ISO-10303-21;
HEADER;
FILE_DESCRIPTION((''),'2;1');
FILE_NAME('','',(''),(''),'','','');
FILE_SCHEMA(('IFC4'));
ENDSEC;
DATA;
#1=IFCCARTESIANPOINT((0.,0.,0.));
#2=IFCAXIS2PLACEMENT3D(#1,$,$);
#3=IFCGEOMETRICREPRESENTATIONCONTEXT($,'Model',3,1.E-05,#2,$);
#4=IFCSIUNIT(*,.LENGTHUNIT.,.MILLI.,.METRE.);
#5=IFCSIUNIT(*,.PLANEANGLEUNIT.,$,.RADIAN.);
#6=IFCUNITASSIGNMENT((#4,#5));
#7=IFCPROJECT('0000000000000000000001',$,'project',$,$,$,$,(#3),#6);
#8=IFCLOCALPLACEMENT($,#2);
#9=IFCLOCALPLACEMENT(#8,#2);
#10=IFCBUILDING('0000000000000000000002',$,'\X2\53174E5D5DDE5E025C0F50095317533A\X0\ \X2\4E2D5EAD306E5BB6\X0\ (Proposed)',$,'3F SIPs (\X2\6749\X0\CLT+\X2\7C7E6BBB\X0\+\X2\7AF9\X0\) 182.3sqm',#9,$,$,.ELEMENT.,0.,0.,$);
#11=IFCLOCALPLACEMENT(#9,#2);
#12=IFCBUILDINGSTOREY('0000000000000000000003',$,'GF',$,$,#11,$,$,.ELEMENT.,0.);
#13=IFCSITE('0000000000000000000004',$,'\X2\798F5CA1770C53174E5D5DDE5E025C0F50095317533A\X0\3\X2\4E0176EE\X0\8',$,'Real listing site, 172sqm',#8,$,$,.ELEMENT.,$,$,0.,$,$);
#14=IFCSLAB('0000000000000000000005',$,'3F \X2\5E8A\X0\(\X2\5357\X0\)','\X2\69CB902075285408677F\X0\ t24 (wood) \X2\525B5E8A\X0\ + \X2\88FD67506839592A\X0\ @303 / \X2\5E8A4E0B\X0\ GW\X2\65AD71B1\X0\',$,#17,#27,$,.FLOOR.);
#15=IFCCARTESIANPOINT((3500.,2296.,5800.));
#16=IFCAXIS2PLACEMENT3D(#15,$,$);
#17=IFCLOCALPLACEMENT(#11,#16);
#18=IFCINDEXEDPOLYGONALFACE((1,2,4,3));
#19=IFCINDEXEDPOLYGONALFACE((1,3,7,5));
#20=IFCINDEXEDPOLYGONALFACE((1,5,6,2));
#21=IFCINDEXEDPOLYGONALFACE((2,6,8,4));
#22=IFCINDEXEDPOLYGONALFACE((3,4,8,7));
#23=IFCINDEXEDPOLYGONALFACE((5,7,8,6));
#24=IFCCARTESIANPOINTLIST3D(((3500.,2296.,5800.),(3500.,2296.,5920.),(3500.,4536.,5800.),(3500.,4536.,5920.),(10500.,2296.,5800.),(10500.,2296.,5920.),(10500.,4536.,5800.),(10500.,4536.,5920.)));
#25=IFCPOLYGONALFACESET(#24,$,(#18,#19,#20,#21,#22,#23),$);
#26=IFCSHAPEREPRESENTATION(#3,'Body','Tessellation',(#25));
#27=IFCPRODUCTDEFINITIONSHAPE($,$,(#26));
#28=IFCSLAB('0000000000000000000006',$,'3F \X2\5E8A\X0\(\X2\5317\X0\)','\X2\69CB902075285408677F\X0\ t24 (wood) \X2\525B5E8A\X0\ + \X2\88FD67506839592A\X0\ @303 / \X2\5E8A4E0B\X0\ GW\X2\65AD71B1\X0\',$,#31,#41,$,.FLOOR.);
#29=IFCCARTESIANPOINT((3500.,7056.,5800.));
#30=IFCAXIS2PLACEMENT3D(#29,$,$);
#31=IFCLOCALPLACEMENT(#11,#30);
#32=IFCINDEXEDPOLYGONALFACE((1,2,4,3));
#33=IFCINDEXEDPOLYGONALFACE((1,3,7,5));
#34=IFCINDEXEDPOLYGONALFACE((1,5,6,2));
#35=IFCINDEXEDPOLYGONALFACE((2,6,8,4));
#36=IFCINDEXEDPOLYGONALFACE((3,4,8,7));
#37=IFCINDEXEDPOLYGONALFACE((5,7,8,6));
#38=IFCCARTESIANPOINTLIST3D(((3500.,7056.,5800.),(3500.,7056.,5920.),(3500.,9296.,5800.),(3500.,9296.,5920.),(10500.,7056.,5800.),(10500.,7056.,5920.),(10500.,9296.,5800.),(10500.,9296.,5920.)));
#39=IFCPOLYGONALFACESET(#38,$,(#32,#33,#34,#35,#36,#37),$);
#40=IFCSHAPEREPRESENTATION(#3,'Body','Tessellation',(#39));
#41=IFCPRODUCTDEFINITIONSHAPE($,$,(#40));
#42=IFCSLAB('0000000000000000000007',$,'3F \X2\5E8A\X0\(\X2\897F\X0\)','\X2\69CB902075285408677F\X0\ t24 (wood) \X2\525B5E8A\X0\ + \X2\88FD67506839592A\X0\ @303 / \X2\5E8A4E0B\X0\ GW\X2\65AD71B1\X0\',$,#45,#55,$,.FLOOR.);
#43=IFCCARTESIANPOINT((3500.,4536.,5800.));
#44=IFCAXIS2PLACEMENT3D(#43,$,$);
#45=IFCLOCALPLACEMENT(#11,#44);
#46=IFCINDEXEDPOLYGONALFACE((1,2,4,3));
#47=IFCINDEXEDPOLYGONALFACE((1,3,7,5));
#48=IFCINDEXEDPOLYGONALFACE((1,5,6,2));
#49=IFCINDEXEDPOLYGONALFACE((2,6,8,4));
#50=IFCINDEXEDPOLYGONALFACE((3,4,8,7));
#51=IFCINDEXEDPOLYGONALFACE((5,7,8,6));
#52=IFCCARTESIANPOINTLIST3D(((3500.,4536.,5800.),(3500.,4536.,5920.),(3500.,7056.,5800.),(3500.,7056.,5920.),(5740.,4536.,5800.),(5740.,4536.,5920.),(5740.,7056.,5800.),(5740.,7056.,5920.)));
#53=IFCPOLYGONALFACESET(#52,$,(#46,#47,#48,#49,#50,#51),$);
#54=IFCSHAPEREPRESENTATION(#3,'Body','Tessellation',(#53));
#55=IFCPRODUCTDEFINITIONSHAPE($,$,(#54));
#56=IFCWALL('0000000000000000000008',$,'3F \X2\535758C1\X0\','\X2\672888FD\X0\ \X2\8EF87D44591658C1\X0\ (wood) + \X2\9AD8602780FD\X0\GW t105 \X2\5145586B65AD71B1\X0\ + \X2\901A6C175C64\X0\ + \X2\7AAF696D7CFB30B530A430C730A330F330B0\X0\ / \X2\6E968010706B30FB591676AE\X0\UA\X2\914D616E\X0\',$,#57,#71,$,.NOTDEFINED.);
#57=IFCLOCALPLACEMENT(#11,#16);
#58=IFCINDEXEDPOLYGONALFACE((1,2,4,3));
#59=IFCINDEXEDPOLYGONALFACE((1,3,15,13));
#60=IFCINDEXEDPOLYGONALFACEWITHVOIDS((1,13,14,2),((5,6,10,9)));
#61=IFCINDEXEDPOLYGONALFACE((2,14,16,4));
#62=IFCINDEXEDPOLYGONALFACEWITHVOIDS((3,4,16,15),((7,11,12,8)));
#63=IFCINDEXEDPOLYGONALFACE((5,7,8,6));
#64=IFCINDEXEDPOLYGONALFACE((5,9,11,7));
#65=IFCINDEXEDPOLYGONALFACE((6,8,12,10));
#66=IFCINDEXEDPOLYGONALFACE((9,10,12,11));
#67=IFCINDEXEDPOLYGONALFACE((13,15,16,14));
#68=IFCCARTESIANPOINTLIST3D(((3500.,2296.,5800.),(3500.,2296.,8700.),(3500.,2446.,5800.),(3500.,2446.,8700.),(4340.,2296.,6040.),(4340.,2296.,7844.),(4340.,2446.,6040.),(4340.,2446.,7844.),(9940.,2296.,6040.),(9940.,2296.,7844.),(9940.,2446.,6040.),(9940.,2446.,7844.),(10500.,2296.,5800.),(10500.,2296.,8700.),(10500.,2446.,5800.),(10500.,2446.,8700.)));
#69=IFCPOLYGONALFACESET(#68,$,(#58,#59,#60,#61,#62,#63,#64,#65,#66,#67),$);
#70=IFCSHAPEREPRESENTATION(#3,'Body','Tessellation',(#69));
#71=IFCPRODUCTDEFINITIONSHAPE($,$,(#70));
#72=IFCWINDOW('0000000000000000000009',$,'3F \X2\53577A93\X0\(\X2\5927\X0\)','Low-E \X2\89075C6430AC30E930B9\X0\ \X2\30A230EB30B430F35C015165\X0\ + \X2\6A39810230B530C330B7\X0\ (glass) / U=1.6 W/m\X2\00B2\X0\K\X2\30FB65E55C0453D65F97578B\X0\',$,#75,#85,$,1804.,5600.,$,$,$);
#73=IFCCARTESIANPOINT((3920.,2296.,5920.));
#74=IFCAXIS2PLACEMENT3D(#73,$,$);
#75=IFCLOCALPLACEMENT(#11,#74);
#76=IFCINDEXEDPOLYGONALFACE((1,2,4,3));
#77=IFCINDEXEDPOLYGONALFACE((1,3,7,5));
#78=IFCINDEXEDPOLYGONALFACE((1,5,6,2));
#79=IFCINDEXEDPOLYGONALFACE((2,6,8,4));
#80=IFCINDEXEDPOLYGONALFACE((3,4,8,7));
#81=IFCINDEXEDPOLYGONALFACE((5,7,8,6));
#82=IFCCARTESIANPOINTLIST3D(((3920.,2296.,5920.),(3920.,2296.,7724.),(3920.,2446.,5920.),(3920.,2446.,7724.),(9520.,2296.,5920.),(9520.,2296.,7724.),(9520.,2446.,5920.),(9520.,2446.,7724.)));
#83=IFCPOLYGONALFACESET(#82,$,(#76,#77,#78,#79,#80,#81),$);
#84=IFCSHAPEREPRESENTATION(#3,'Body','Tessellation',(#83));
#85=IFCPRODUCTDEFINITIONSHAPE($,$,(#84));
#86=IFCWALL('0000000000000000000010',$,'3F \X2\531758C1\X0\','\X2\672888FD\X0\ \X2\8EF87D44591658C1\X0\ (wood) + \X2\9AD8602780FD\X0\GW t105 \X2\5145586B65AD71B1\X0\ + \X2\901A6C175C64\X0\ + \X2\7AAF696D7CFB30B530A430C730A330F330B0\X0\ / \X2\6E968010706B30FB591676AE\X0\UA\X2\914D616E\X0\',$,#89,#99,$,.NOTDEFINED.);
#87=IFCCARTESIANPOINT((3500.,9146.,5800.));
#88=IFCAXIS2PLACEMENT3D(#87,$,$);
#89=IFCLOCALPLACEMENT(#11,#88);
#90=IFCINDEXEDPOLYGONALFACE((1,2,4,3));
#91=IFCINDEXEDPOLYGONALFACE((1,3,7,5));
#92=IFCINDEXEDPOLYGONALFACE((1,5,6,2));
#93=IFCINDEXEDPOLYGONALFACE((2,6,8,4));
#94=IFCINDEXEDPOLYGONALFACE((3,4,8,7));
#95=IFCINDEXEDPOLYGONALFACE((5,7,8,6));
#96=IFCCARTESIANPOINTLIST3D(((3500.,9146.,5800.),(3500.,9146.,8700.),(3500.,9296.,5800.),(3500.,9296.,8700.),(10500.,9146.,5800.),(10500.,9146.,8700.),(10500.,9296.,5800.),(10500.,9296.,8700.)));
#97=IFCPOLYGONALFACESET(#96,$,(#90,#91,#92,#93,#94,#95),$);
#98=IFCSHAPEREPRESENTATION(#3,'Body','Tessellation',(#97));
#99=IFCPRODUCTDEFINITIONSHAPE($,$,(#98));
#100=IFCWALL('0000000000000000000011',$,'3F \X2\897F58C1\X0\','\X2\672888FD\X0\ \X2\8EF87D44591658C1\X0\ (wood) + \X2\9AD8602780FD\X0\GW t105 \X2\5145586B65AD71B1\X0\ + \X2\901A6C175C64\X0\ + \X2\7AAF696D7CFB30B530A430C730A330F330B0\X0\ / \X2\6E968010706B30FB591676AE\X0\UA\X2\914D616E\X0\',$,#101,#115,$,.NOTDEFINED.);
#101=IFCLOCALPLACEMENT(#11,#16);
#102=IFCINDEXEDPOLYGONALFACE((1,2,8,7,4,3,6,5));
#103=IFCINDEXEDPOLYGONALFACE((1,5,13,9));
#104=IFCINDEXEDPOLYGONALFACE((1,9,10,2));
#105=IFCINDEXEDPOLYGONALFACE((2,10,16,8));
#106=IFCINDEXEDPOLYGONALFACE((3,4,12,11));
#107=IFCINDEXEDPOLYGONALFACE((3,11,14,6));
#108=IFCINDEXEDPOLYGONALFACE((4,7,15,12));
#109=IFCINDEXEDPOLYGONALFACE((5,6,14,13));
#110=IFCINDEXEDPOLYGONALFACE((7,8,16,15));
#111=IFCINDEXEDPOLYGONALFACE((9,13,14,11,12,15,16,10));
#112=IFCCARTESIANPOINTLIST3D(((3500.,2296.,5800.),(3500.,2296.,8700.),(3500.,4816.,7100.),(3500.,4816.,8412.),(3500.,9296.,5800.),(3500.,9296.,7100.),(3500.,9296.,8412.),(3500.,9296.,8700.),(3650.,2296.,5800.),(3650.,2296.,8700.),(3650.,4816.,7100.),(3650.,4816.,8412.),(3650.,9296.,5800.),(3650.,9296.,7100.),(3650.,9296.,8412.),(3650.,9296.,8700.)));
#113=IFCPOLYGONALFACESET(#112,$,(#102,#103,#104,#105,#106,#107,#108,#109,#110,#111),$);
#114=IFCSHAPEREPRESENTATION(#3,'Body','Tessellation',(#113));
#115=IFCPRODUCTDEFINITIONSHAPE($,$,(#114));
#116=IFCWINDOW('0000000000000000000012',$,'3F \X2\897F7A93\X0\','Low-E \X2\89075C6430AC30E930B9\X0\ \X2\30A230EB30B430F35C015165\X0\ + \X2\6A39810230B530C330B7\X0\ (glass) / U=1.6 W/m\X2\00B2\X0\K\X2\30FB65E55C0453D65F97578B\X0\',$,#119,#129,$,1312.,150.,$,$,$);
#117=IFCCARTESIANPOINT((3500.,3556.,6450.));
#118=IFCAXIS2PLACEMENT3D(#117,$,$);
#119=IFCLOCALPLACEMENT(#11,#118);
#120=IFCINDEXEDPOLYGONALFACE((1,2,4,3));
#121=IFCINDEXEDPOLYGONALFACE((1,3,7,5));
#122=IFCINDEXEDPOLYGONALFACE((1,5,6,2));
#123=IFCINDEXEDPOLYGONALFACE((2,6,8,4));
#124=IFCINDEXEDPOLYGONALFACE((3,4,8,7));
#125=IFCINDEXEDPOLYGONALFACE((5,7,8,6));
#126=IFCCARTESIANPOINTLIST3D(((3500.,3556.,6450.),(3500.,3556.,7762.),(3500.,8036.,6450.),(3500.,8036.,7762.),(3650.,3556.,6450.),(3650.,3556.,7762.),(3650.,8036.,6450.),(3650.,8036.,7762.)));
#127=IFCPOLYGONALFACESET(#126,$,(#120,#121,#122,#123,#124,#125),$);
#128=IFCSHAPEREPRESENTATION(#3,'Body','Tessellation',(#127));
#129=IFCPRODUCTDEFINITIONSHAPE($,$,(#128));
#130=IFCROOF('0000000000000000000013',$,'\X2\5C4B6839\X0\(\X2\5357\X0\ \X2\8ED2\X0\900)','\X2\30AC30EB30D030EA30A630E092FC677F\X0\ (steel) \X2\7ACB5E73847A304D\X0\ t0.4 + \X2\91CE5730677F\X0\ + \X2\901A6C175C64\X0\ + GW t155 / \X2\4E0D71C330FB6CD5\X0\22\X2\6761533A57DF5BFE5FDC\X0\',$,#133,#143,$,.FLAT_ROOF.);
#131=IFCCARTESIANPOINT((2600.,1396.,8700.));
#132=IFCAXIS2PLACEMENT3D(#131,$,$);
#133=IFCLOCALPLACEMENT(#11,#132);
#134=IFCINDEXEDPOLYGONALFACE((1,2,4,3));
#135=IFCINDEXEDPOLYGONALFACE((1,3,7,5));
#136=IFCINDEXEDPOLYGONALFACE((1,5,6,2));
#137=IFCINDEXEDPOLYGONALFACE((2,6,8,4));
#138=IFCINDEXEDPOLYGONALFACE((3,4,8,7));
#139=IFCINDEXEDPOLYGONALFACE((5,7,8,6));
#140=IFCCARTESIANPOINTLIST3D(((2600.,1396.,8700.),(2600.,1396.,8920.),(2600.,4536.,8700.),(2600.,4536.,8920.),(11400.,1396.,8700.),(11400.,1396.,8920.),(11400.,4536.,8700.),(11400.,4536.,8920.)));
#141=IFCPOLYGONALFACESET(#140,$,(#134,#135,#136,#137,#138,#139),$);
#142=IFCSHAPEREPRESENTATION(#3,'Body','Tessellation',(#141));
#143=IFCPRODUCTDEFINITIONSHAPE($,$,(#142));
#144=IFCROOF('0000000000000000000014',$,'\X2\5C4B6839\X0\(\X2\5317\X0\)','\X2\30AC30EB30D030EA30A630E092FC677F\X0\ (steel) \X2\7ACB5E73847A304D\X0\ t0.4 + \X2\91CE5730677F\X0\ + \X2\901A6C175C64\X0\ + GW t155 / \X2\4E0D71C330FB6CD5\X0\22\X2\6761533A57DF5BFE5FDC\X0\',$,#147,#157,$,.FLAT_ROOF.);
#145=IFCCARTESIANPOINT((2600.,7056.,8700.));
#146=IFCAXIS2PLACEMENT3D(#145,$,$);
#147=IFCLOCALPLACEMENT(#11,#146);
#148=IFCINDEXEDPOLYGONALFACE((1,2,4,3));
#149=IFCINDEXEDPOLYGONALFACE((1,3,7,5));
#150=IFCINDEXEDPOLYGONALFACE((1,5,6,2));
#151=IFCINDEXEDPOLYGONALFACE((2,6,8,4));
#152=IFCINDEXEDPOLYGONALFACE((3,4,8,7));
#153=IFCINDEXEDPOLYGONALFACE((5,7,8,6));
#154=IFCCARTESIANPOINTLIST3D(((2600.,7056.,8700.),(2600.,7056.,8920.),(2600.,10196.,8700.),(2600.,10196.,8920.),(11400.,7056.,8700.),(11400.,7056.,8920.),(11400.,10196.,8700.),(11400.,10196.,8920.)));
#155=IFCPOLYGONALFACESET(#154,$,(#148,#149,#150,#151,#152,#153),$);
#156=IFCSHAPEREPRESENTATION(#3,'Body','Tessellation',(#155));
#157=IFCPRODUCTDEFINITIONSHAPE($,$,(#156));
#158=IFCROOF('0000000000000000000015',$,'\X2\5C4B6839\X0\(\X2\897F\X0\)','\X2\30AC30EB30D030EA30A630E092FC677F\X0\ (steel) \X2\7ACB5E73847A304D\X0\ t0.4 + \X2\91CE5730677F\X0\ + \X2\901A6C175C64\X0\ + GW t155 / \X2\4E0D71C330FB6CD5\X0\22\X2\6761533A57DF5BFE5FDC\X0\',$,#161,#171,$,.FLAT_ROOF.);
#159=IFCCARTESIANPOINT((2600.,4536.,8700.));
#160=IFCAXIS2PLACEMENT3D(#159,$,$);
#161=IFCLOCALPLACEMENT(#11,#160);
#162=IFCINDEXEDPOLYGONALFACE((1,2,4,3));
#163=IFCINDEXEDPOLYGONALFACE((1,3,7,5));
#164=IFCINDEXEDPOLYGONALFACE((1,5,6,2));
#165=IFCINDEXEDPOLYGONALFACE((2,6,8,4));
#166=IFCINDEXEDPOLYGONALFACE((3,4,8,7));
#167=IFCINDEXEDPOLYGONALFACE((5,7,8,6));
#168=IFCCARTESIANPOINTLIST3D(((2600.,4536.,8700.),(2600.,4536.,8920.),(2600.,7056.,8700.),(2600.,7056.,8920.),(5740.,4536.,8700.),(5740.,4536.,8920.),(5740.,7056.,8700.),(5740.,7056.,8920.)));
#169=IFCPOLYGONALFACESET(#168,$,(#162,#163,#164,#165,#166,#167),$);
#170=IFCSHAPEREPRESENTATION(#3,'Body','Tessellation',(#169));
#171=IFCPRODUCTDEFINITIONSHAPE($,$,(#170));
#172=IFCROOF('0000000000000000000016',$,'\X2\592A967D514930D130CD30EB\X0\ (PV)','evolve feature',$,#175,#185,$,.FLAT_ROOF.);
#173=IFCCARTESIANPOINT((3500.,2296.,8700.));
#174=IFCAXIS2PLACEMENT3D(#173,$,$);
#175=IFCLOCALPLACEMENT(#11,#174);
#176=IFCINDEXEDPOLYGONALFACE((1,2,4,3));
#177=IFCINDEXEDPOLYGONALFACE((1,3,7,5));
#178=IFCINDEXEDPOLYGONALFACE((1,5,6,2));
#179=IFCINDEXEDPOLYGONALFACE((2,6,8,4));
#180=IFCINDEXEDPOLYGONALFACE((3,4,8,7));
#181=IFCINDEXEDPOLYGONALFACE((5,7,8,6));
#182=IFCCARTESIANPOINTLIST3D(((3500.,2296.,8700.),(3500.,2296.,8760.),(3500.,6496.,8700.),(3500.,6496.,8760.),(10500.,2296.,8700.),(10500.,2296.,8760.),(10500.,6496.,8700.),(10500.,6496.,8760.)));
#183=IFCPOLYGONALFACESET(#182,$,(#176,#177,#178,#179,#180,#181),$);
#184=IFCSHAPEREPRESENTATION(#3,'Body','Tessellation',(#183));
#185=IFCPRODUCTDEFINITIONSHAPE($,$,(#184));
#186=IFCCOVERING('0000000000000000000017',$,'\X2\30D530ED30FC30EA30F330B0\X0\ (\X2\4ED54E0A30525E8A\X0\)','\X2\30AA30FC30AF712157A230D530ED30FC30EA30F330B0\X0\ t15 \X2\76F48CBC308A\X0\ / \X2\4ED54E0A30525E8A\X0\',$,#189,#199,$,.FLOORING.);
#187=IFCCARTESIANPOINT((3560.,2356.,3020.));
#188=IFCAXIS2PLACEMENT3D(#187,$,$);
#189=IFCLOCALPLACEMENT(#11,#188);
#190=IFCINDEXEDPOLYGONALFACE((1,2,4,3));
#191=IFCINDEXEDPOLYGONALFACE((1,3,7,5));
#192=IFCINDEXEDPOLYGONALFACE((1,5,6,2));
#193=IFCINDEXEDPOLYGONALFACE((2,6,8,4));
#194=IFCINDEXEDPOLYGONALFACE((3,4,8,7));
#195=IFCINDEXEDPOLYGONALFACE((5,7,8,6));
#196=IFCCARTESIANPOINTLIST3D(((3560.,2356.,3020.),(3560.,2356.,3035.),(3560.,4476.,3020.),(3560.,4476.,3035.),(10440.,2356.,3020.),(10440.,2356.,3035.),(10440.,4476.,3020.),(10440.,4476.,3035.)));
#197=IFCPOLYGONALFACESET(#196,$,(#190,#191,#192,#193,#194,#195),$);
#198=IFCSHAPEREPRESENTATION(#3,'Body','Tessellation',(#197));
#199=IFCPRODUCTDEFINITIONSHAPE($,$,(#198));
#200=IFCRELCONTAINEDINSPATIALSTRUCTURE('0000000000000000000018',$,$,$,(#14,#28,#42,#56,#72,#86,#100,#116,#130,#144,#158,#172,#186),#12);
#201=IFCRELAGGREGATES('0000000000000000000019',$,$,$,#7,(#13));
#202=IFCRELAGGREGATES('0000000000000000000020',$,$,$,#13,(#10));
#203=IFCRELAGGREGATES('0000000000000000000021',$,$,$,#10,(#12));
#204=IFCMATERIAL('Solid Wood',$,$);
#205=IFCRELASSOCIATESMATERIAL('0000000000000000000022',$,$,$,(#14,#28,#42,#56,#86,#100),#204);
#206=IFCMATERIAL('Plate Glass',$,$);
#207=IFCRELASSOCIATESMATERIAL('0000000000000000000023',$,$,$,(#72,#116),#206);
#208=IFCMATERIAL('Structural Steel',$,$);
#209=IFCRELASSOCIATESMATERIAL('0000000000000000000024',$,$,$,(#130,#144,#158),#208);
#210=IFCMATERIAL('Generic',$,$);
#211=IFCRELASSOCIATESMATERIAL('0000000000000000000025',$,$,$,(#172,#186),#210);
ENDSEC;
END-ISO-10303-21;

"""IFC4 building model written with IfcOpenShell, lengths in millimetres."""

from ifc_helpers import new_model, si_unit, frame, frame_2d, origin, place, context, project, spatial, rectangle, extrude, material, element, fill, save


model = new_model("IFC4")

# Units and contexts
model_context = context("Model", 3, precision=1e-05, world=origin())
ifc_project = project(units=[si_unit("LENGTHUNIT", "METRE", prefix="MILLI"), si_unit("PLANEANGLEUNIT", "RADIAN")], contexts=[model_context])

# Site, building, storey
site_placement = place(None, origin())
site = spatial("IfcSite", under=ifc_project, at=site_placement, Name="福岡県北九州市小倉北区3丁目8", ObjectType="Real listing site, 172sqm", CompositionType="ELEMENT", RefElevation=0.0)
building_placement = place(site_placement, origin())
building = spatial("IfcBuilding", under=site, at=building_placement, Name="北九州市小倉北区 中庭の家 (Proposed)", ObjectType="3F SIPs (杉CLT+籾殻+竹) 182.3sqm", CompositionType="ELEMENT", ElevationOfRefHeight=0.0, ElevationOfTerrain=0.0)
storey_placement = place(building_placement, origin())
storey = spatial("IfcBuildingStorey", under=building, at=storey_placement, Name="GF", CompositionType="ELEMENT", Elevation=0.0)

# Slabs
ifc_material_1 = material(Name="Solid Wood")
slab_1_placement = place(storey_placement, frame((3500.0, 2296.0, 5800.0)))
element("IfcSlab", 1, at=slab_1_placement, inside=storey, material=ifc_material_1, Name="3F 床(南)", Description="構造用合板 t24 (wood) 剛床 + 製材根太 @303 / 床下 GW断熱", PredefinedType="FLOOR", context=model_context, shape_type="SweptSolid", body=[
    extrude(rectangle(XDim=7000.0, YDim=2240.0, at=frame_2d((3500.0, 1120.0))), frame((3500.0, 2296.0, 5800.0)), (0.0, 0.0, 1.0), 120.0),
])
slab_2_placement = place(storey_placement, frame((3500.0, 7056.0, 5800.0)))
element("IfcSlab", 2, at=slab_2_placement, inside=storey, material=ifc_material_1, Name="3F 床(北)", Description="構造用合板 t24 (wood) 剛床 + 製材根太 @303 / 床下 GW断熱", PredefinedType="FLOOR", context=model_context, shape_type="SweptSolid", body=[
    extrude(rectangle(XDim=7000.0, YDim=2240.0, at=frame_2d((3500.0, 1120.0))), frame((3500.0, 7056.0, 5800.0)), (0.0, 0.0, 1.0), 120.0),
])
slab_3_placement = place(storey_placement, frame((3500.0, 4536.0, 5800.0)))
element("IfcSlab", 3, at=slab_3_placement, inside=storey, material=ifc_material_1, Name="3F 床(西)", Description="構造用合板 t24 (wood) 剛床 + 製材根太 @303 / 床下 GW断熱", PredefinedType="FLOOR", context=model_context, shape_type="SweptSolid", body=[
    extrude(rectangle(XDim=2240.0, YDim=2520.0, at=frame_2d((1120.0, 1260.0))), frame((3500.0, 4536.0, 5800.0)), (0.0, 0.0, 1.0), 120.0),
])

# Wall, opening, window
wall_1_placement = place(storey_placement, frame((3500.0, 2296.0, 5800.0)))
wall_1 = element("IfcWall", 4, at=wall_1_placement, inside=storey, material=ifc_material_1, Name="3F 南壁", Description="木製 軸組外壁 (wood) + 高性能GW t105 充填断熱 + 通気層 + 窯業系サイディング / 準耐火・外皮UA配慮", PredefinedType="NOTDEFINED", context=model_context, shape_type="SweptSolid", body=[
    extrude(rectangle(XDim=7000.0, YDim=150.0, at=frame_2d((3500.0, 75.0))), frame((3500.0, 2296.0, 5800.0)), (0.0, 0.0, 1.0), 2900.0),
])
opening_1_placement = place(storey_placement, frame((3920.0, 2296.0, 5920.0)))
opening_1 = element("IfcOpeningElement", 5, at=opening_1_placement, cuts=wall_1, PredefinedType="NOTDEFINED", context=model_context, shape_type="SweptSolid", body=[
    extrude(rectangle(XDim=5600.0, YDim=150.0, at=frame_2d((2800.0, 75.0))), frame((3920.0, 2296.0, 5920.0)), (0.0, 0.0, 1.0), 1804.0),
])
ifc_material_2 = material(Name="Plate Glass")
window_1_placement = place(storey_placement, frame((3920.0, 2296.0, 5920.0)))
window_1 = element("IfcWindow", 6, at=window_1_placement, inside=storey, material=ifc_material_2, Name="3F 南窓(大)", Description="Low-E 複層ガラス アルゴン封入 + 樹脂サッシ (glass) / U=1.6 W/m²K・日射取得型", OverallHeight=1804.0, OverallWidth=5600.0, context=model_context, shape_type="SweptSolid", body=[
    extrude(rectangle(XDim=5600.0, YDim=150.0, at=frame_2d((2800.0, 75.0))), frame((3920.0, 2296.0, 5920.0)), (0.0, 0.0, 1.0), 1804.0),
])
fill(opening_1, window_1)

# Wall
wall_2_placement = place(storey_placement, frame((3500.0, 9146.0, 5800.0)))
element("IfcWall", 7, at=wall_2_placement, inside=storey, material=ifc_material_1, Name="3F 北壁", Description="木製 軸組外壁 (wood) + 高性能GW t105 充填断熱 + 通気層 + 窯業系サイディング / 準耐火・外皮UA配慮", PredefinedType="NOTDEFINED", context=model_context, shape_type="SweptSolid", body=[
    extrude(rectangle(XDim=7000.0, YDim=150.0, at=frame_2d((3500.0, 75.0))), frame((3500.0, 9146.0, 5800.0)), (0.0, 0.0, 1.0), 2900.0),
])

# Wall, opening, window
wall_3_placement = place(storey_placement, frame((3500.0, 2296.0, 5800.0)))
wall_3 = element("IfcWall", 8, at=wall_3_placement, inside=storey, material=ifc_material_1, Name="3F 西壁", Description="木製 軸組外壁 (wood) + 高性能GW t105 充填断熱 + 通気層 + 窯業系サイディング / 準耐火・外皮UA配慮", PredefinedType="NOTDEFINED", context=model_context, shape_type="SweptSolid", body=[
    extrude(rectangle(XDim=150.0, YDim=7000.0, at=frame_2d((75.0, 3500.0))), frame((3500.0, 2296.0, 5800.0)), (0.0, 0.0, 1.0), 2900.0),
])
opening_2_placement = place(storey_placement, frame((3500.0, 3556.0, 6450.0)))
opening_2 = element("IfcOpeningElement", 9, at=opening_2_placement, cuts=wall_3, PredefinedType="NOTDEFINED", context=model_context, shape_type="SweptSolid", body=[
    extrude(rectangle(XDim=150.0, YDim=4480.0, at=frame_2d((75.0, 2240.0))), frame((3500.0, 3556.0, 6450.0)), (0.0, 0.0, 1.0), 1312.0),
])
window_2_placement = place(storey_placement, frame((3500.0, 3556.0, 6450.0)))
window_2 = element("IfcWindow", 10, at=window_2_placement, inside=storey, material=ifc_material_2, Name="3F 西窓", Description="Low-E 複層ガラス アルゴン封入 + 樹脂サッシ (glass) / U=1.6 W/m²K・日射取得型", OverallHeight=1312.0, OverallWidth=150.0, context=model_context, shape_type="SweptSolid", body=[
    extrude(rectangle(XDim=150.0, YDim=4480.0, at=frame_2d((75.0, 2240.0))), frame((3500.0, 3556.0, 6450.0)), (0.0, 0.0, 1.0), 1312.0),
])
fill(opening_2, window_2)

# Roofs
ifc_material_3 = material(Name="Structural Steel")
roof_1_placement = place(storey_placement, frame((2600.0, 1396.0, 8700.0)))
element("IfcRoof", 11, at=roof_1_placement, inside=storey, material=ifc_material_3, Name="屋根(南 軒900)", Description="ガルバリウム鋼板 (steel) 立平葺き t0.4 + 野地板 + 通気層 + GW t155 / 不燃・法22条区域対応", PredefinedType="FLAT_ROOF", context=model_context, shape_type="SweptSolid", body=[
    extrude(rectangle(XDim=8800.0, YDim=3140.0, at=frame_2d((4400.0, 1570.0))), frame((2600.0, 1396.0, 8700.0)), (0.0, 0.0, 1.0), 220.0),
])
roof_2_placement = place(storey_placement, frame((2600.0, 7056.0, 8700.0)))
element("IfcRoof", 12, at=roof_2_placement, inside=storey, material=ifc_material_3, Name="屋根(北)", Description="ガルバリウム鋼板 (steel) 立平葺き t0.4 + 野地板 + 通気層 + GW t155 / 不燃・法22条区域対応", PredefinedType="FLAT_ROOF", context=model_context, shape_type="SweptSolid", body=[
    extrude(rectangle(XDim=8800.0, YDim=3140.0, at=frame_2d((4400.0, 1570.0))), frame((2600.0, 7056.0, 8700.0)), (0.0, 0.0, 1.0), 220.0),
])
roof_3_placement = place(storey_placement, frame((2600.0, 4536.0, 8700.0)))
element("IfcRoof", 13, at=roof_3_placement, inside=storey, material=ifc_material_3, Name="屋根(西)", Description="ガルバリウム鋼板 (steel) 立平葺き t0.4 + 野地板 + 通気層 + GW t155 / 不燃・法22条区域対応", PredefinedType="FLAT_ROOF", context=model_context, shape_type="SweptSolid", body=[
    extrude(rectangle(XDim=3140.0, YDim=2520.0, at=frame_2d((1570.0, 1260.0))), frame((2600.0, 4536.0, 8700.0)), (0.0, 0.0, 1.0), 220.0),
])
ifc_material_4 = material(Name="Generic")
roof_4_placement = place(storey_placement, frame((3500.0, 2296.0, 8700.0)))
element("IfcRoof", 14, at=roof_4_placement, inside=storey, material=ifc_material_4, Name="太陽光パネル (PV)", Description="evolve feature", PredefinedType="FLAT_ROOF", context=model_context, shape_type="SweptSolid", body=[
    extrude(rectangle(XDim=7000.0, YDim=4200.0, at=frame_2d((3500.0, 2100.0))), frame((3500.0, 2296.0, 8700.0)), (0.0, 0.0, 1.0), 60.0),
])

# Covering
covering_1_placement = place(storey_placement, frame((3560.0, 2356.0, 3020.0)))
element("IfcCovering", 15, at=covering_1_placement, inside=storey, material=ifc_material_4, Name="フローリング (仕上げ床)", Description="オーク無垢フローリング t15 直貼り / 仕上げ床", PredefinedType="FLOORING", context=model_context, shape_type="SweptSolid", body=[
    extrude(rectangle(XDim=6880.0, YDim=2120.0, at=frame_2d((3440.0, 1060.0))), frame((3560.0, 2356.0, 3020.0)), (0.0, 0.0, 1.0), 15.0),
])

save(model, "model.ifc")
